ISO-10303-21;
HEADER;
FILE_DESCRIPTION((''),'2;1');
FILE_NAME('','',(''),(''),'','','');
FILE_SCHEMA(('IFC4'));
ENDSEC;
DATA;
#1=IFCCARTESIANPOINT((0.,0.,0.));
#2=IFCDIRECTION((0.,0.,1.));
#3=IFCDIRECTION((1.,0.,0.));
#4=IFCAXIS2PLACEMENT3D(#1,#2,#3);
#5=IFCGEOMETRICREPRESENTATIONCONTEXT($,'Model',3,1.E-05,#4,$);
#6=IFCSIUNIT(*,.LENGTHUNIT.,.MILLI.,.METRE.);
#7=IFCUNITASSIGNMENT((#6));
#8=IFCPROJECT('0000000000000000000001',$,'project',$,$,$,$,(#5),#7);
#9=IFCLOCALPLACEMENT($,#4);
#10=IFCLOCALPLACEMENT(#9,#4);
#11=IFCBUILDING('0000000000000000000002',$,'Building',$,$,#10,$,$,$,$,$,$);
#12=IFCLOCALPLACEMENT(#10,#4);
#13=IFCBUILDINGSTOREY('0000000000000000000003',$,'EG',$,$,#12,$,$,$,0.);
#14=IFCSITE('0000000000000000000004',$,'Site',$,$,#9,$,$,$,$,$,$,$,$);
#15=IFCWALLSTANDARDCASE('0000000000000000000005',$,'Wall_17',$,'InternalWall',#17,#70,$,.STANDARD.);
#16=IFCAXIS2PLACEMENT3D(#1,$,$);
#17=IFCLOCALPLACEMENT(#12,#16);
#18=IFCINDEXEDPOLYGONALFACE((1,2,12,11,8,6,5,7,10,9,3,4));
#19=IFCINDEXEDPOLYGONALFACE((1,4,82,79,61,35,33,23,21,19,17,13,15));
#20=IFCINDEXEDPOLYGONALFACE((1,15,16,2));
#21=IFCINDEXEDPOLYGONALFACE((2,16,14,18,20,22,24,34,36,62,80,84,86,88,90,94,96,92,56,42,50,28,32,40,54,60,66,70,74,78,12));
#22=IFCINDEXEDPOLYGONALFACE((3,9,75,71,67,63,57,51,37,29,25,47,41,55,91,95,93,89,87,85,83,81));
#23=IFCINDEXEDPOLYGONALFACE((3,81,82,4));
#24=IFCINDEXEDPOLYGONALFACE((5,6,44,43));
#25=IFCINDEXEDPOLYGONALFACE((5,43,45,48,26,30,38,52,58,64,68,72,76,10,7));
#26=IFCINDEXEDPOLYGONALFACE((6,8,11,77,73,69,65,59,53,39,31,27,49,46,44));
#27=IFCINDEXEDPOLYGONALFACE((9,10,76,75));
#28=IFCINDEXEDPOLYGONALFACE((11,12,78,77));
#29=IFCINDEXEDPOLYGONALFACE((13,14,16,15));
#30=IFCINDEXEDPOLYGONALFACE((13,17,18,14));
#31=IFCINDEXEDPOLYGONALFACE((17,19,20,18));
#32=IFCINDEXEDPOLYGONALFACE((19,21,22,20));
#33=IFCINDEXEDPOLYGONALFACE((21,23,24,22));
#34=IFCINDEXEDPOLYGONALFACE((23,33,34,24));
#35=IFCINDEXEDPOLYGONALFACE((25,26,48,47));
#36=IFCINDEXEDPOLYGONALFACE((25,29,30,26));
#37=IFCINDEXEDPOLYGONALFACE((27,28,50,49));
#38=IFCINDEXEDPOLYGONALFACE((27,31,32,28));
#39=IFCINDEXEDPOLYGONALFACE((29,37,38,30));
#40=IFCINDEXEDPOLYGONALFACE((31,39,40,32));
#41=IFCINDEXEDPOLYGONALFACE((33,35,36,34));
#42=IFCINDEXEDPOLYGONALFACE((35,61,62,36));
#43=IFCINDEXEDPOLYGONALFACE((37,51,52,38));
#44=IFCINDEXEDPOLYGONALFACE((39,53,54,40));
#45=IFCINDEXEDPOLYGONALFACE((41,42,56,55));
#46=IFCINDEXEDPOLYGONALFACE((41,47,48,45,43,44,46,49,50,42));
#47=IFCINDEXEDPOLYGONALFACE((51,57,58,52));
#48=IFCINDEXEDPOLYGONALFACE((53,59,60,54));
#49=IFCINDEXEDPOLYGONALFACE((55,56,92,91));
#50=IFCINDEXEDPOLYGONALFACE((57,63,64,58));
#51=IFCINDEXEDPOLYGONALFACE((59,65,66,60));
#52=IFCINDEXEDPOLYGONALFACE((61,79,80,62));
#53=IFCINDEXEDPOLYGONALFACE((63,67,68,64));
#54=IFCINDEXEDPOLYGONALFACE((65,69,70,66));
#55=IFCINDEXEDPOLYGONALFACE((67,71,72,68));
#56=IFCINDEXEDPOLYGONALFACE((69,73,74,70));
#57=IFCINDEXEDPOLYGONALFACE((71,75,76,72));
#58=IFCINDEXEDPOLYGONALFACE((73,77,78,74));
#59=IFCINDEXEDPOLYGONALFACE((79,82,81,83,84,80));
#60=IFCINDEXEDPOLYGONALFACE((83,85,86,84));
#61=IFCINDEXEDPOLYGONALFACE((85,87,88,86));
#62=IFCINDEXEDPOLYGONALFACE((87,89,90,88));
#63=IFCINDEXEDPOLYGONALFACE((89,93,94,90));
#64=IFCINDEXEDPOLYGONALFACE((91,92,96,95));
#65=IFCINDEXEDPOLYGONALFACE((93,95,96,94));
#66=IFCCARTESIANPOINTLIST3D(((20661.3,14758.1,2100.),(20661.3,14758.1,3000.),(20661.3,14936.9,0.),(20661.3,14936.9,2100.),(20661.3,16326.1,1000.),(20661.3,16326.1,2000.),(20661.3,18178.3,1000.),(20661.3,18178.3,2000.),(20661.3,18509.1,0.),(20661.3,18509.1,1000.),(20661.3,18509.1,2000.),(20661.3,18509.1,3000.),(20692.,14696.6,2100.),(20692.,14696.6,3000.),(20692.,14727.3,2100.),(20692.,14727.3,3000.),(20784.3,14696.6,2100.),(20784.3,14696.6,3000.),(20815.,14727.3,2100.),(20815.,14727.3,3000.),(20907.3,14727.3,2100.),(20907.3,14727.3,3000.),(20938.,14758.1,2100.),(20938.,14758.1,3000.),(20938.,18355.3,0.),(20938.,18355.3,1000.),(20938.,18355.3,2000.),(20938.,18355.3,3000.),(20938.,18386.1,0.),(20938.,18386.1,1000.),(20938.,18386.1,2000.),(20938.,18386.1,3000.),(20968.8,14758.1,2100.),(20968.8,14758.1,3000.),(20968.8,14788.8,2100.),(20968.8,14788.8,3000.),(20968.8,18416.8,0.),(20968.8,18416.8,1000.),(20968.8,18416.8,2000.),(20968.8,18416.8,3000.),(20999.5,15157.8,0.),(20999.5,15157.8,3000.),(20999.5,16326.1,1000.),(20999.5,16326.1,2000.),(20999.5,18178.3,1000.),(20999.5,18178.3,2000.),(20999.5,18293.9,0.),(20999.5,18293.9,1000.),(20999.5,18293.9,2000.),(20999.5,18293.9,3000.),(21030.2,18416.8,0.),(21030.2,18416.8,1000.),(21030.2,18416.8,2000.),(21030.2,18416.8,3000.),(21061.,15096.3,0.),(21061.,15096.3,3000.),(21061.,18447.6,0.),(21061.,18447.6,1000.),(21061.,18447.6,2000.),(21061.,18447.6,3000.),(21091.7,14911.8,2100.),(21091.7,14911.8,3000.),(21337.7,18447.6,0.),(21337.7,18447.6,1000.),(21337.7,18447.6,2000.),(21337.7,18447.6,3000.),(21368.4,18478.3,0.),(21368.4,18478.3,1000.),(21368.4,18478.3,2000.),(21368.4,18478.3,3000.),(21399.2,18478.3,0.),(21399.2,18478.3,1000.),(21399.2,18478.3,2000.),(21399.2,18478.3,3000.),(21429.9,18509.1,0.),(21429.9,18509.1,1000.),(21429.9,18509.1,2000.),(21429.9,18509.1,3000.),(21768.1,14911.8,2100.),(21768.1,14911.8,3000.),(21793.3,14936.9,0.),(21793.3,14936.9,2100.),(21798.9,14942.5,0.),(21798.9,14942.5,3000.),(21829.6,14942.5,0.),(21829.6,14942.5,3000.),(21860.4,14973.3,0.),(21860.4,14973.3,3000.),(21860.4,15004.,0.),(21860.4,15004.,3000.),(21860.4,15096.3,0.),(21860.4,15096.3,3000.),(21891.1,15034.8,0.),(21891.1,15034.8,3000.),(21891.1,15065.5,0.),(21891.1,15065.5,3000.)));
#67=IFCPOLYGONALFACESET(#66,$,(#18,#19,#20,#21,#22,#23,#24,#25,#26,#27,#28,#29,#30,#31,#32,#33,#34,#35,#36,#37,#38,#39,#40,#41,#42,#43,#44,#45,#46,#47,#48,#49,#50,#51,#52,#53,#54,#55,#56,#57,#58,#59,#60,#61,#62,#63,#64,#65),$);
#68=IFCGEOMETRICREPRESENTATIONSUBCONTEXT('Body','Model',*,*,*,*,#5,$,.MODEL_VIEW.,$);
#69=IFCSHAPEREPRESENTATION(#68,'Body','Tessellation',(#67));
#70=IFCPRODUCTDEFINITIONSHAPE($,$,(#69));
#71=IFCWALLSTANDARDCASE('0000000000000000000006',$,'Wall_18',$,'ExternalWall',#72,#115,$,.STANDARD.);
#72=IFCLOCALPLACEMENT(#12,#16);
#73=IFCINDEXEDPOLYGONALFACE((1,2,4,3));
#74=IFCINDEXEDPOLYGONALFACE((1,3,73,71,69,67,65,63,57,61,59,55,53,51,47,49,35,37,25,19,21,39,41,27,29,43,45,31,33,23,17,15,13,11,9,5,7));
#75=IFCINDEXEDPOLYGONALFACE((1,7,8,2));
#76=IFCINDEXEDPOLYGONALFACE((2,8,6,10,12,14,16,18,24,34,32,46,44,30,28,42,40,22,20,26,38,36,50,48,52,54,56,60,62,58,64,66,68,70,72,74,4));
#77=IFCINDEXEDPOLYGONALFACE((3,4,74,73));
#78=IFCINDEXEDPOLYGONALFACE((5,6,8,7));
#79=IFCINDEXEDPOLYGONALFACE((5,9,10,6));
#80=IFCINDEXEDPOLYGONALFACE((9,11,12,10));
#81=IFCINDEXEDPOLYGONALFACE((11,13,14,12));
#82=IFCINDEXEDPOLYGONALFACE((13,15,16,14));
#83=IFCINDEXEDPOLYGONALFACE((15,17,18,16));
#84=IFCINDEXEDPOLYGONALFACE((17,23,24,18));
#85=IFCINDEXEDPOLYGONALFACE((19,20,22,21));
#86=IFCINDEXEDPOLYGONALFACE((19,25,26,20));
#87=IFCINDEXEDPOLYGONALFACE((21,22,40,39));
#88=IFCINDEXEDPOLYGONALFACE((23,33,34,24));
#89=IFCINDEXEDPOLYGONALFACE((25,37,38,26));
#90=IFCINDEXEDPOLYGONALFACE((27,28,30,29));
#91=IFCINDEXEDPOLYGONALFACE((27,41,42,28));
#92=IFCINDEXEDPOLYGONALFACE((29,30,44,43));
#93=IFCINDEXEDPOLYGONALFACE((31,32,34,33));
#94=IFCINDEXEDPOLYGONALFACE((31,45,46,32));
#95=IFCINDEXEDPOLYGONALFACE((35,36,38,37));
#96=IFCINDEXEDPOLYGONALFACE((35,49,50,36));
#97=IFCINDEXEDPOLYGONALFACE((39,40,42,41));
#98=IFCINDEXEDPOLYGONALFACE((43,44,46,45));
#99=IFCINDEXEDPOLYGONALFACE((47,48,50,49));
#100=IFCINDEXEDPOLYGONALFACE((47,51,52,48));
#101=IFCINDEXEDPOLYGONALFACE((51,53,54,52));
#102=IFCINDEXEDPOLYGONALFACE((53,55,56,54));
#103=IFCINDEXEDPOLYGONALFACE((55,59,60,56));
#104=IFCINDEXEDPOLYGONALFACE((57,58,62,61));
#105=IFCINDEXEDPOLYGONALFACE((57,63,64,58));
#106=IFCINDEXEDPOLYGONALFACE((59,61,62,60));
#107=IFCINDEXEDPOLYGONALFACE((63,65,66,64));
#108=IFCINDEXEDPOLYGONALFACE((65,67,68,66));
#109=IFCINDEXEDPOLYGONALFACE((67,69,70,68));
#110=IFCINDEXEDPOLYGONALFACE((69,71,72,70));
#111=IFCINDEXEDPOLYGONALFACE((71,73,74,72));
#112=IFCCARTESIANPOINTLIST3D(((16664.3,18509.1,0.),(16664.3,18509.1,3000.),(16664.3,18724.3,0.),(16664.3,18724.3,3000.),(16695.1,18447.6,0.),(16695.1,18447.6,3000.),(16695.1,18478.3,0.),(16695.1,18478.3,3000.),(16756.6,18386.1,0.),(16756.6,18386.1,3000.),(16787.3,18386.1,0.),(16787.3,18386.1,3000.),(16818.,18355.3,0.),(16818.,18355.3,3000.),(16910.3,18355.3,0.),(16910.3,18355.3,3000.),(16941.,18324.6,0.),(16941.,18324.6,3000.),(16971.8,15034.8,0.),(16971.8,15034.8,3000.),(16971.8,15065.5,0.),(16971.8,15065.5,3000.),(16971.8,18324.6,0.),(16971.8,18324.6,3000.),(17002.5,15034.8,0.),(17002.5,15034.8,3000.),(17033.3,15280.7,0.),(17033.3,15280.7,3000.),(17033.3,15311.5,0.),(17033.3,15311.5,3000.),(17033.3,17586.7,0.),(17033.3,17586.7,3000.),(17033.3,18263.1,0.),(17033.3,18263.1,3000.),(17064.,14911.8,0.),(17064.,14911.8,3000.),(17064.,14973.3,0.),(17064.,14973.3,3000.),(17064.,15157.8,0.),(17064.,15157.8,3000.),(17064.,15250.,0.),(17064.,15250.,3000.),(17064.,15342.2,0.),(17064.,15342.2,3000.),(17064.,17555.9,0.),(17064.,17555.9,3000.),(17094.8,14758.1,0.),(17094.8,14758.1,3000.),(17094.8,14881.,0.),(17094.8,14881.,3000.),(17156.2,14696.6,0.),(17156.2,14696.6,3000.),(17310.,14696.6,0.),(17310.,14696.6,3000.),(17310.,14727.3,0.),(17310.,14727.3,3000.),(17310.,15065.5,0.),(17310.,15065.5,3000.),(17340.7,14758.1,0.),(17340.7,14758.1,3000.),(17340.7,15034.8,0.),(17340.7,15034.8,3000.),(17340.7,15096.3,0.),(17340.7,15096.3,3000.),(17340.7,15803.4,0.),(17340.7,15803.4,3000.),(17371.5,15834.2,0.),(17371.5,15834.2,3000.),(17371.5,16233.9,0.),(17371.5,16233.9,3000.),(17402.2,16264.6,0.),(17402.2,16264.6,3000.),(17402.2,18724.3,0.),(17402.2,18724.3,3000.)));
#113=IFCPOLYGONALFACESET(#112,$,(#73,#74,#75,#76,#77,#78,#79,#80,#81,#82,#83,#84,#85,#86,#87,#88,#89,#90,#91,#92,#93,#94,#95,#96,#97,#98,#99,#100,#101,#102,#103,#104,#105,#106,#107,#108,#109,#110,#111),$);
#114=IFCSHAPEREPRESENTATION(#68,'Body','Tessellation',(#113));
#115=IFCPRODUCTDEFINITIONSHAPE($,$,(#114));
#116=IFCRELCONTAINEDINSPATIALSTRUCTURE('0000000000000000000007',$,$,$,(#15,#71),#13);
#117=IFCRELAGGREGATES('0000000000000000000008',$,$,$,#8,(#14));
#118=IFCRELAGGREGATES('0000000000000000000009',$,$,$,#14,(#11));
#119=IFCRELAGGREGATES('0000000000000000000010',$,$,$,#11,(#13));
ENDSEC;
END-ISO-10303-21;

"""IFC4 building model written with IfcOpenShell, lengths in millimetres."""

from ifc_helpers import new_model, si_unit, frame, origin_with_axes, place, context, subcontext, project, spatial, polyline, rectangle, outline, extrude, element, save


model = new_model("IFC4")

# Units and contexts
model_context = context("Model", 3, precision=1e-05, world=origin_with_axes())
body_context = subcontext(model_context, "Body", "Model", "MODEL_VIEW")
ifc_project = project(units=[si_unit("LENGTHUNIT", "METRE", prefix="MILLI")], contexts=[model_context])

# Site, building, storey
site_placement = place(None, origin_with_axes())
site = spatial("IfcSite", under=ifc_project, at=site_placement, Name="Site")
building_placement = place(site_placement, origin_with_axes())
building = spatial("IfcBuilding", under=site, at=building_placement, Name="Building")
storey_placement = place(building_placement, origin_with_axes())
storey = spatial("IfcBuildingStorey", under=building, at=storey_placement, Name="EG", Elevation=0.0)

# Wall, openings
wall_1_placement = place(storey_placement, origin_with_axes())
wall_1 = element("IfcWallStandardCase", 1, at=wall_1_placement, inside=storey, Name="Wall_17", ObjectType="InternalWall", PredefinedType="STANDARD", context=body_context, shape_type="SweptSolid", body=[
    extrude(outline(polyline([(20692.0, 14696.6, 0.0), (20692.0, 14727.3, 0.0), (20661.3, 14758.1, 0.0), (20661.3, 18509.1, 0.0), (21429.9, 18509.1, 0.0), (21399.2, 18478.3, 0.0), (21368.4, 18478.3, 0.0), (21337.7, 18447.6, 0.0), (21061.0, 18447.6, 0.0), (21030.2, 18416.8, 0.0), (20968.8, 18416.8, 0.0), (20938.0, 18386.1, 0.0), (20938.0, 18355.3, 0.0), (20999.5, 18293.9, 0.0), (20999.5, 15157.8, 0.0), (21061.0, 15096.3, 0.0), (21860.4, 15096.3, 0.0), (21891.1, 15065.5, 0.0), (21891.1, 15034.8, 0.0), (21860.4, 15004.0, 0.0), (21860.4, 14973.3, 0.0), (21829.6, 14942.5, 0.0), (21798.9, 14942.5, 0.0), (21768.1, 14911.8, 0.0), (21091.7, 14911.8, 0.0), (20968.8, 14788.8, 0.0), (20968.8, 14758.1, 0.0), (20938.0, 14758.1, 0.0), (20907.3, 14727.3, 0.0), (20815.0, 14727.3, 0.0), (20784.3, 14696.6, 0.0), (20692.0, 14696.6, 0.0)])), origin_with_axes(), (0.0, 0.0, 1.0), 3000.0),
])
opening_1_placement = place(wall_1_placement, origin_with_axes())
element("IfcOpeningElement", 2, at=opening_1_placement, inside=storey, cuts=wall_1, context=body_context, shape_type="SweptSolid", body=[
    extrude(rectangle(XDim=450.0, YDim=1229.8), frame((21276.2, 14711.9, 0.0), z_axis=(0.0, 0.0, 1.0), x_axis=(0.0, -1.0, 0.0)), (0.0, 0.0, 1.0), 2100.0),
])
opening_2_placement = place(wall_1_placement, origin_with_axes())
element("IfcOpeningElement", 3, at=opening_2_placement, inside=storey, cuts=wall_1, context=body_context, shape_type="SweptSolid", body=[
    extrude(rectangle(XDim=600.0, YDim=1229.8), frame((21276.2, 18478.3, 1000.0), z_axis=(0.0, 0.0, 1.0), x_axis=(0.0, -1.0, 0.0)), (0.0, 0.0, 1.0), 1000.0),
])
opening_3_placement = place(wall_1_placement, origin_with_axes())
element("IfcOpeningElement", 4, at=opening_3_placement, inside=storey, cuts=wall_1, context=body_context, shape_type="SweptSolid", body=[
    extrude(rectangle(XDim=2183.0, YDim=1229.8), frame((21276.2, 17417.6, 1000.0), z_axis=(0.0, 0.0, 1.0), x_axis=(0.0, -1.0, 0.0)), (0.0, 0.0, 1.0), 1000.0),
])

# Wall, opening
wall_2_placement = place(storey_placement, origin_with_axes())
wall_2 = element("IfcWallStandardCase", 5, at=wall_2_placement, inside=storey, Name="Wall_18", ObjectType="ExternalWall", PredefinedType="STANDARD", context=body_context, shape_type="SweptSolid", body=[
    extrude(outline(polyline([(17156.2, 14696.6, 0.0), (17094.8, 14758.1, 0.0), (17094.8, 14881.0, 0.0), (17064.0, 14911.8, 0.0), (17064.0, 14973.3, 0.0), (17002.5, 15034.8, 0.0), (16971.8, 15034.8, 0.0), (16971.8, 15065.5, 0.0), (17064.0, 15157.8, 0.0), (17064.0, 15250.0, 0.0), (17033.3, 15280.7, 0.0), (17033.3, 15311.5, 0.0), (17064.0, 15342.2, 0.0), (17064.0, 17555.9, 0.0), (17033.3, 17586.7, 0.0), (17033.3, 18263.1, 0.0), (16971.8, 18324.6, 0.0), (16941.0, 18324.6, 0.0), (16910.3, 18355.3, 0.0), (16818.0, 18355.3, 0.0), (16787.3, 18386.1, 0.0), (16756.6, 18386.1, 0.0), (16695.1, 18447.6, 0.0), (16695.1, 18478.3, 0.0), (16664.3, 18509.1, 0.0), (16664.3, 18724.3, 0.0), (17402.2, 18724.3, 0.0), (17402.2, 16264.6, 0.0), (17371.5, 16233.9, 0.0), (17371.5, 15834.2, 0.0), (17340.7, 15803.4, 0.0), (17340.7, 15096.3, 0.0), (17310.0, 15065.5, 0.0), (17340.7, 15034.8, 0.0), (17340.7, 14758.1, 0.0), (17310.0, 14727.3, 0.0), (17310.0, 14696.6, 0.0), (17156.2, 14696.6, 0.0)])), origin_with_axes(), (0.0, 0.0, 1.0), 3000.0),
])
opening_4_placement = place(wall_2_placement, origin_with_axes())
element("IfcOpeningElement", 6, at=opening_4_placement, inside=storey, cuts=wall_2, context=body_context, shape_type="SweptSolid", body=[
    extrude(rectangle(XDim=900.0, YDim=737.9), frame((16885.0, 14146.8, 0.0), z_axis=(0.0, 0.0, 1.0), x_axis=(0.0, -1.0, 0.0)), (0.0, 0.0, 1.0), 2100.0),
])

save(model, "model.ifc")
